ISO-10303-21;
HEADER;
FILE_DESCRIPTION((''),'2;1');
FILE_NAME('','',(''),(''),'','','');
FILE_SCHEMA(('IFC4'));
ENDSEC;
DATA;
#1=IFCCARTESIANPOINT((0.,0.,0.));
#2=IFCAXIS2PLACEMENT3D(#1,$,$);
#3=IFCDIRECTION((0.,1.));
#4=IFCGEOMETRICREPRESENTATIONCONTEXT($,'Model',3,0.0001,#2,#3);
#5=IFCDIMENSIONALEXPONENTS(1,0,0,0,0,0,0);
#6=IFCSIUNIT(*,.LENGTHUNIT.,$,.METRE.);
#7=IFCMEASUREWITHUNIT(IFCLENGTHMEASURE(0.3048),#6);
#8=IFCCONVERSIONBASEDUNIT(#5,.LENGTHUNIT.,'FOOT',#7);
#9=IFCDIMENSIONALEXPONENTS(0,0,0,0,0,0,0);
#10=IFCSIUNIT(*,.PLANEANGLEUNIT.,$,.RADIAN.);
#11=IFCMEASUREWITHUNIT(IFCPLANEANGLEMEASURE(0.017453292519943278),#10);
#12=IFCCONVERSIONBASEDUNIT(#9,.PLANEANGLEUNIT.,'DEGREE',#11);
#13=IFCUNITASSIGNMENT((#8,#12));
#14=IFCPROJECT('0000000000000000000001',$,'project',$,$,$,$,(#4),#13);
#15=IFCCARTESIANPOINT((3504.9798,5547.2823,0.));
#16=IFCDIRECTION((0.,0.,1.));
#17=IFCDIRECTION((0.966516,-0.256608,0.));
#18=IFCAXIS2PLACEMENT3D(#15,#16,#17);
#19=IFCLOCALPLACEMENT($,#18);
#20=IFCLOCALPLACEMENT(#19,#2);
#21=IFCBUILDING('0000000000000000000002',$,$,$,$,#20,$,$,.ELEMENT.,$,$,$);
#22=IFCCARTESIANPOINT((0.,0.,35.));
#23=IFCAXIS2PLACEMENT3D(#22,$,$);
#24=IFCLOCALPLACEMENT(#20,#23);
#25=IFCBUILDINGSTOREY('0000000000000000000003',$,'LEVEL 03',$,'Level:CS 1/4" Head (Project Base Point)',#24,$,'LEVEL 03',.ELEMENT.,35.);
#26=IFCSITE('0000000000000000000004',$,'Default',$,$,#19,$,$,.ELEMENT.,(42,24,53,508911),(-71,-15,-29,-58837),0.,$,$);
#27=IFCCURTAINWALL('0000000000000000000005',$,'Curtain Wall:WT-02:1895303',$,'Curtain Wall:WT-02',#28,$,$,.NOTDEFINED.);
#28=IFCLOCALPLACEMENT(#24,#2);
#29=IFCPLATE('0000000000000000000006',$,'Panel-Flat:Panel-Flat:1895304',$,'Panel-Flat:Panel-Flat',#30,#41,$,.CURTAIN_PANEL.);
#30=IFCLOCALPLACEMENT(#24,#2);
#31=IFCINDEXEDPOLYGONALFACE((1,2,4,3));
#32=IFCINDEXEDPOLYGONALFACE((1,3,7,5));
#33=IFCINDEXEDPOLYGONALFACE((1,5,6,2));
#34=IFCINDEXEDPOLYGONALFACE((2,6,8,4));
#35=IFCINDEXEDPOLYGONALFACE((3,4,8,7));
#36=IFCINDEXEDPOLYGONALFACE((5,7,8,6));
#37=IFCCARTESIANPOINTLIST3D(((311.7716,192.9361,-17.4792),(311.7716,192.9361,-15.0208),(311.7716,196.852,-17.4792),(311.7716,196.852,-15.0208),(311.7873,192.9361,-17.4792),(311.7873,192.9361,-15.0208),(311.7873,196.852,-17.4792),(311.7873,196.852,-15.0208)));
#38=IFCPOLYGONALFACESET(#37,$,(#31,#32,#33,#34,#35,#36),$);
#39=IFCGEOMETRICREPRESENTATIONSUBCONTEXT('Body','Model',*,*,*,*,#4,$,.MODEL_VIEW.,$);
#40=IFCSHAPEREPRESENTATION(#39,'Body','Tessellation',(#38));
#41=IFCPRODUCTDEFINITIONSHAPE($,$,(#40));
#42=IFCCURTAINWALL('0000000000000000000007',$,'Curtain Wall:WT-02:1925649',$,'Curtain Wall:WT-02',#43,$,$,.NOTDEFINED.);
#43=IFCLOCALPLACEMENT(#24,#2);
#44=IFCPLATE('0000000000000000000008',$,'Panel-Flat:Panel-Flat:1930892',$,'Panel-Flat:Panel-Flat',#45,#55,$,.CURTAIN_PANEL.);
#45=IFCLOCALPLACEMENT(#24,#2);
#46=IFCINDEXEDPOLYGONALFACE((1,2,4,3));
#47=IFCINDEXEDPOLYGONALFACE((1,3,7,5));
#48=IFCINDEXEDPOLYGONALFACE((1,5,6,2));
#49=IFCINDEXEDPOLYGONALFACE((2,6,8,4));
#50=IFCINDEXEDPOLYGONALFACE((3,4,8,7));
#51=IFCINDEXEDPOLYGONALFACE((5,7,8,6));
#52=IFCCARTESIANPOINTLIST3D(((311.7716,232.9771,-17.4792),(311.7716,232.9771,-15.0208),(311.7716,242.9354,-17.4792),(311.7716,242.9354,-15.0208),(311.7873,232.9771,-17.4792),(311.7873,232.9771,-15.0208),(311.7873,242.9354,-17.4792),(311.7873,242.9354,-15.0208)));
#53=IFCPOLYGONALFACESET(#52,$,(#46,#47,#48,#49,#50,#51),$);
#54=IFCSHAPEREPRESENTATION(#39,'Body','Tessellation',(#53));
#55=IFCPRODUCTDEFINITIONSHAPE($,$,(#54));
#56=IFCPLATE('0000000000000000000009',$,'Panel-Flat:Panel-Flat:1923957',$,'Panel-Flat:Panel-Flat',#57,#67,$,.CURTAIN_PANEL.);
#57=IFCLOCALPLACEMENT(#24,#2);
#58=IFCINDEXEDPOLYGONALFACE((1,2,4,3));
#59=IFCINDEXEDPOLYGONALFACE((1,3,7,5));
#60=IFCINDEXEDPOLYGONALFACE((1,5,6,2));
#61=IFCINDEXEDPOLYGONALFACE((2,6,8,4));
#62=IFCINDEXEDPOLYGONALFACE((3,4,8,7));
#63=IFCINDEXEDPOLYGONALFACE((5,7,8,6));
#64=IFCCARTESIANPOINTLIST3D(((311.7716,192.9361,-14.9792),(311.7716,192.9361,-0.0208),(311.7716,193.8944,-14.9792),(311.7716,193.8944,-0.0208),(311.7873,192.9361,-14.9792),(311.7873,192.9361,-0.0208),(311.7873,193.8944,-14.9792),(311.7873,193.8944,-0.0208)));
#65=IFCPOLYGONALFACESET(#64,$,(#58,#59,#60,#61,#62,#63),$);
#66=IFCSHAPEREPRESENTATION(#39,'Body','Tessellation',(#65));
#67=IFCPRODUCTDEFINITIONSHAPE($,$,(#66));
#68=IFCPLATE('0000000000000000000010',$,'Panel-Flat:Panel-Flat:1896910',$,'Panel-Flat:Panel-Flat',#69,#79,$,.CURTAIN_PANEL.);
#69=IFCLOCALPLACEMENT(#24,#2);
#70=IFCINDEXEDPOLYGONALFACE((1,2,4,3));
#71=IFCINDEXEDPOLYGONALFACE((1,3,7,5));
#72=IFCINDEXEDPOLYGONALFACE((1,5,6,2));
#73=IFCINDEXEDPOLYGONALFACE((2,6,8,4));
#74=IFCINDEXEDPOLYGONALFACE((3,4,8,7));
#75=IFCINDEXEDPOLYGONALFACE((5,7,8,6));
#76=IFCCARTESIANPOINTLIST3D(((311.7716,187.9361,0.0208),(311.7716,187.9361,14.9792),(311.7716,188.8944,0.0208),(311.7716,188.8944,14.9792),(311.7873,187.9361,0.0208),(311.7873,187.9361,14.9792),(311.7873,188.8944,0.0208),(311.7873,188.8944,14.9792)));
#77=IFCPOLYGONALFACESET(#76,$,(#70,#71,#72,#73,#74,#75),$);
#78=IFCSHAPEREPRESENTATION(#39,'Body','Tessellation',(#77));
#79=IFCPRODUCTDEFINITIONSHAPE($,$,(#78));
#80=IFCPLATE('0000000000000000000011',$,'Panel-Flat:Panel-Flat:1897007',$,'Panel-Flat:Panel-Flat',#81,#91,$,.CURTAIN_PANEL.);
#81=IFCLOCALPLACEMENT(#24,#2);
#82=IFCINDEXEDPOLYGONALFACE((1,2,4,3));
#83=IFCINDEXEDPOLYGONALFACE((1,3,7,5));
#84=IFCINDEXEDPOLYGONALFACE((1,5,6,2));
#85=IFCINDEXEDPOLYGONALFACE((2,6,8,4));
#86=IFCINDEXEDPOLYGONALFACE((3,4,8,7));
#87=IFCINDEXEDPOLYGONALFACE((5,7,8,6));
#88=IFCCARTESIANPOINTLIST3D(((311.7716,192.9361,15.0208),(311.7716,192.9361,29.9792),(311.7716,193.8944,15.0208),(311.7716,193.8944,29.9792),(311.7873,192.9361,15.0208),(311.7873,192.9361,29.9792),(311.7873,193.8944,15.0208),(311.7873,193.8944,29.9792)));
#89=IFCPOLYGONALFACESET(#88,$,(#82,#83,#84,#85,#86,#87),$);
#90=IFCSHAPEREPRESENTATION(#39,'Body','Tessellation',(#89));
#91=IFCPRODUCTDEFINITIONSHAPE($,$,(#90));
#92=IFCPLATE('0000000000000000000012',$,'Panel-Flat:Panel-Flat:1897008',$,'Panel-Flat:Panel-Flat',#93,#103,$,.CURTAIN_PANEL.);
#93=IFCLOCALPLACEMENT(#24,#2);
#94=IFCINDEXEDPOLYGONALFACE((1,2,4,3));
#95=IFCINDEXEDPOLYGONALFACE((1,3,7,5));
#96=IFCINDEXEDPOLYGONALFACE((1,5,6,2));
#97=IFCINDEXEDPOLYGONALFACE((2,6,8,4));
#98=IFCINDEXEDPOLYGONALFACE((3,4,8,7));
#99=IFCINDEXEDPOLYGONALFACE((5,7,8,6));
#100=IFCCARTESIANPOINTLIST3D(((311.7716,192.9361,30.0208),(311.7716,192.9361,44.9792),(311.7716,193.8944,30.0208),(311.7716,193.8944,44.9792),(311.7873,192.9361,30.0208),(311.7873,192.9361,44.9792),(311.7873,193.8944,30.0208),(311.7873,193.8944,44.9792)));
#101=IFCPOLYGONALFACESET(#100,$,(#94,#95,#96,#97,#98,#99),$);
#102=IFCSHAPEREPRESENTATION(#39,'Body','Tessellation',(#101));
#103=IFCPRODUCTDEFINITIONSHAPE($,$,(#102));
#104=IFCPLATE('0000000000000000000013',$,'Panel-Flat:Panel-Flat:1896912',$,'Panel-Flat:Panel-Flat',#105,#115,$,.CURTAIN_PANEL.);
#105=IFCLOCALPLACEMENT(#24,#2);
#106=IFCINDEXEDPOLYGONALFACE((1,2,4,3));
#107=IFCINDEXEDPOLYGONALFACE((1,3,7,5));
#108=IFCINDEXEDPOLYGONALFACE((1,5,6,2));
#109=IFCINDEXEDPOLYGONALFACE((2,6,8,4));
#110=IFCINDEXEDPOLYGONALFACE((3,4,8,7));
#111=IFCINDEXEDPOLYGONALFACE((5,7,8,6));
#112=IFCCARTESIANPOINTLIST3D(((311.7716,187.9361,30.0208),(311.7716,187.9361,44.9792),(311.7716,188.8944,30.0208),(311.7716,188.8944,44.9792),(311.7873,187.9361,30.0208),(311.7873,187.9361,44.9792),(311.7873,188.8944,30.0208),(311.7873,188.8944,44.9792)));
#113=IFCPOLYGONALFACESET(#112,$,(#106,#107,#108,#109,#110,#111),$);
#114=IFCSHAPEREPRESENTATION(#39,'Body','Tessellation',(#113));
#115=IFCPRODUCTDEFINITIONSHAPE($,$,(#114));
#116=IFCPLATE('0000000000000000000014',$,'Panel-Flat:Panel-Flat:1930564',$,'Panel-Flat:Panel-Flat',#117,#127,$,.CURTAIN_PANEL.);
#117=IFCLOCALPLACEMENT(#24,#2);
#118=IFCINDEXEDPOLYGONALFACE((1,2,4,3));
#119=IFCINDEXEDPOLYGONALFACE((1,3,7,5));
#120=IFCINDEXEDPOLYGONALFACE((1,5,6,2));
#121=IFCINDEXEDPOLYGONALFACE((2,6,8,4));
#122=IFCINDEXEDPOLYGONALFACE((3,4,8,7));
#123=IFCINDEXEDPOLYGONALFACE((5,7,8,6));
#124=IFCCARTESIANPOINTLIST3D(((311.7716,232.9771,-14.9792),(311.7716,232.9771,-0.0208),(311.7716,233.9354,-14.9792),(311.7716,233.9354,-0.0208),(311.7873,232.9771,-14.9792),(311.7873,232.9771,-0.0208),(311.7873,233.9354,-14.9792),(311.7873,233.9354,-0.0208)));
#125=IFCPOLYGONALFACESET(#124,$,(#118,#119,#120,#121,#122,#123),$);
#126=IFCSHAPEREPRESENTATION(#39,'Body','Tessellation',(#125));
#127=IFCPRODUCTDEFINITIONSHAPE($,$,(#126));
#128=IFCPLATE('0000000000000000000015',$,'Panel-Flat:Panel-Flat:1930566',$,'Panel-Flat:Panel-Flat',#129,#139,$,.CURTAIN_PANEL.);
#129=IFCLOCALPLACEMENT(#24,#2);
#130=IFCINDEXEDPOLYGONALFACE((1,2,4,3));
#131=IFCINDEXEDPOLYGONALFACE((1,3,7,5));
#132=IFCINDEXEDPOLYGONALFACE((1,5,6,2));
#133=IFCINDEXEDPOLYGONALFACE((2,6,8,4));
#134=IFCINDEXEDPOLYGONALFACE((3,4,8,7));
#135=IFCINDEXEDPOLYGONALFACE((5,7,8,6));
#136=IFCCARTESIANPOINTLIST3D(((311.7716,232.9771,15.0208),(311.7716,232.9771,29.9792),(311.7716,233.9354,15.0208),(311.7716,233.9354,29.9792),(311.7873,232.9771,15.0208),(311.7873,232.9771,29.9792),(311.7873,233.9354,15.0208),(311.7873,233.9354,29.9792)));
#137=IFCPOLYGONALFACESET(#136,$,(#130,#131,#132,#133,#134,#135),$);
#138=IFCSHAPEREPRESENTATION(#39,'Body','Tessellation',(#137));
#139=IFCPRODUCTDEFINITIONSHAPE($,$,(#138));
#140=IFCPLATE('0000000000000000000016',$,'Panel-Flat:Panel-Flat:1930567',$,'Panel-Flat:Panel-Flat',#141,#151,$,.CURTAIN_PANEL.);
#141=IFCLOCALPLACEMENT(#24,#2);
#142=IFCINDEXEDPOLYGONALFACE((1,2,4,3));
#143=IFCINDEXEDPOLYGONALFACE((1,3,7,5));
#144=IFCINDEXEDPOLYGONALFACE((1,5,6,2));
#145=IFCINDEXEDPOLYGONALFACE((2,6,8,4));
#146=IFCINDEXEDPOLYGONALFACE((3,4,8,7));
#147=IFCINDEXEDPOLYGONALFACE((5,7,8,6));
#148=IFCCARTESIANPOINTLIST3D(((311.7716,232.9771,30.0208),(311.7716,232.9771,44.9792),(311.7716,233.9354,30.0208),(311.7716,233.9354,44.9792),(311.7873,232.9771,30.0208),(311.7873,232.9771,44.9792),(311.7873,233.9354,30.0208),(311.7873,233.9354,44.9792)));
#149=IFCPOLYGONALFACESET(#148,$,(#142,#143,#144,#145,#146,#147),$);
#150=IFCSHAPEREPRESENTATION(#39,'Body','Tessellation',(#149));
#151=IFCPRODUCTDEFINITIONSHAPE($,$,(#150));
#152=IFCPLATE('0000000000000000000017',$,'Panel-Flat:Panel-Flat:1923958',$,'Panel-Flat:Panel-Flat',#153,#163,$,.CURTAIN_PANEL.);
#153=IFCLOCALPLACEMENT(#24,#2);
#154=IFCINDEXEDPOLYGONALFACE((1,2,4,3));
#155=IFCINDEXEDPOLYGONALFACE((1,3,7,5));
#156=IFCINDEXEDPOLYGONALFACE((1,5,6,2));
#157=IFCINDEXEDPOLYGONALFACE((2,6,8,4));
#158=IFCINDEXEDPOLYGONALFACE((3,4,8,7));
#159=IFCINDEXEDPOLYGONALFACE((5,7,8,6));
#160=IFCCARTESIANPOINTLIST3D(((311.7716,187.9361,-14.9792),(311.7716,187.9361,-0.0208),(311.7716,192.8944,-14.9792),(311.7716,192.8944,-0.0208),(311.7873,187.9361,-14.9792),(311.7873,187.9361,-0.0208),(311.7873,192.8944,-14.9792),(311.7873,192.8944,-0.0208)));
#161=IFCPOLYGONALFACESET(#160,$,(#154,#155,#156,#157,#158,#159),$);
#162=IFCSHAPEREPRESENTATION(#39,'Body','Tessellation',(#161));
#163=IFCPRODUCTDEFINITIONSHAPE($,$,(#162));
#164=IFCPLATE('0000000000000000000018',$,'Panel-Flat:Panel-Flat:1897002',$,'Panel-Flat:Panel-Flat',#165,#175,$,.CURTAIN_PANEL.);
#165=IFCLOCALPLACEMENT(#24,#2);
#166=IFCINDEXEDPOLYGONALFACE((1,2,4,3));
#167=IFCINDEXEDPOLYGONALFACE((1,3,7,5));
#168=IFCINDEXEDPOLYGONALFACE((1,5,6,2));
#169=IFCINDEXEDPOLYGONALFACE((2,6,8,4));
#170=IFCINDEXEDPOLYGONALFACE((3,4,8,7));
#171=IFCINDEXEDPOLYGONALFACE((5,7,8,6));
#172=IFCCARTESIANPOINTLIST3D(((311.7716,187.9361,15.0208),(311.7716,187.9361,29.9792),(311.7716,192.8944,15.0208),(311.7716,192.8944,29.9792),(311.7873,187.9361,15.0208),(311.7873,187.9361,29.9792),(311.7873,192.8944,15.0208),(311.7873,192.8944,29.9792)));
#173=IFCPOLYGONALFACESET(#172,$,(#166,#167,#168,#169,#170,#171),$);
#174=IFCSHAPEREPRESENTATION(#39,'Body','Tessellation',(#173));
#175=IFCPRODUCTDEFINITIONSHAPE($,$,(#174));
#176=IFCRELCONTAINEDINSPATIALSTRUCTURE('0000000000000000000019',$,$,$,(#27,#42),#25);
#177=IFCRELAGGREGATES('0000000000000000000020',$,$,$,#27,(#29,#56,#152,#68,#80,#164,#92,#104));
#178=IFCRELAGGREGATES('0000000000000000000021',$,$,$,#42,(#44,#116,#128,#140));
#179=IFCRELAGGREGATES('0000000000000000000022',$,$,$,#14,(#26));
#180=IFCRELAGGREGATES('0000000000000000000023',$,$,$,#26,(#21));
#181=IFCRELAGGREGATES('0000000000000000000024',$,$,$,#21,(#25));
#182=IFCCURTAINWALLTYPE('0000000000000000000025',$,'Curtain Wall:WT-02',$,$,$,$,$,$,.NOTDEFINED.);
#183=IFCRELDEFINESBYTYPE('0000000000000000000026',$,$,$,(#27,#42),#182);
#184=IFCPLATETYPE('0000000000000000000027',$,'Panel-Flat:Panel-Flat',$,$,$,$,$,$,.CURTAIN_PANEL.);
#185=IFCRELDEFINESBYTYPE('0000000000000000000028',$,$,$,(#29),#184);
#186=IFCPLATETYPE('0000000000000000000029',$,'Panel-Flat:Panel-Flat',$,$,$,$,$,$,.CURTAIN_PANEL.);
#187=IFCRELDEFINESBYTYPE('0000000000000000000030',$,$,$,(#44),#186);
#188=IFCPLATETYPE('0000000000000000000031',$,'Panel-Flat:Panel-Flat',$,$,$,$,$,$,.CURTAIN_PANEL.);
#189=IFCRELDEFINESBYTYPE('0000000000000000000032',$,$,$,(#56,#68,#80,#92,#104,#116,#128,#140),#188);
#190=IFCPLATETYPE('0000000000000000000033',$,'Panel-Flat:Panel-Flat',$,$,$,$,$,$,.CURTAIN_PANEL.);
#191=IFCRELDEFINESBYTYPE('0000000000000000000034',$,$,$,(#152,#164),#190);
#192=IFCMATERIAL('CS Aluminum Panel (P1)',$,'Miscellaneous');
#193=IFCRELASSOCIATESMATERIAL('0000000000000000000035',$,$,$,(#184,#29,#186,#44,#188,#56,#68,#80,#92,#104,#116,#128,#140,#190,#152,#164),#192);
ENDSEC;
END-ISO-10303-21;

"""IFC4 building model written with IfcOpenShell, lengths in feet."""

from ifc_helpers import new_model, entity, si_unit, converted_unit, direction, frame, origin, place, context, subcontext, project, spatial, indexed_curve, outline, extrude, source, transform, mapped, material, type_object, type_shapes, element, aggregate, save


model = new_model("IFC4")

# Units and contexts
model_context = context("Model", 3, precision=0.0001, world=origin(), true_north=direction((0.0, 1.0)))
body_context = subcontext(model_context, "Body", "Model", "MODEL_VIEW")
ifc_project = project(units=[converted_unit("LENGTHUNIT", "FOOT", entity("IfcLengthMeasure", 0.3048), si_unit("LENGTHUNIT", "METRE"), dimensions=[1, 0, 0, 0, 0, 0, 0]), converted_unit("PLANEANGLEUNIT", "DEGREE", entity("IfcPlaneAngleMeasure", 0.017453292519943278), si_unit("PLANEANGLEUNIT", "RADIAN"), dimensions=[0, 0, 0, 0, 0, 0, 0])], contexts=[model_context])

# Site, building, storey
site_placement = place(None, frame((3504.9798, 5547.2823, 0.0), z_axis=(0.0, 0.0, 1.0), x_axis=(0.966516, -0.256608, 0.0)))
site = spatial("IfcSite", under=ifc_project, at=site_placement, Name="Default", CompositionType="ELEMENT", RefLatitude=(42, 24, 53, 508911), RefLongitude=(-71, -15, -29, -58837), RefElevation=0.0)
building_placement = place(site_placement, origin())
building = spatial("IfcBuilding", under=site, at=building_placement, CompositionType="ELEMENT")
storey_placement = place(building_placement, frame((0.0, 0.0, 35.0)))
storey = spatial("IfcBuildingStorey", under=building, at=storey_placement, Name="LEVEL 03", ObjectType="Level:CS 1/4\" Head (Project Base Point)", LongName="LEVEL 03", CompositionType="ELEMENT", Elevation=35.0)

# Curtain walls, plates
curtain_wall_type = type_object("IfcCurtainWallType", Name="Curtain Wall:WT-02", PredefinedType="NOTDEFINED")
curtain_wall_1_placement = place(storey_placement, frame((0.0, 0.0, -35.0)))
curtain_wall_1 = element("IfcCurtainWall", 1, at=curtain_wall_1_placement, inside=storey, type_object=curtain_wall_type, Name="Curtain Wall:WT-02:1895303", ObjectType="Curtain Wall:WT-02", PredefinedType="NOTDEFINED")
ifc_material_1 = material(Name="CS Aluminum Panel (P1)", Category="Miscellaneous")
plate_type_1 = type_object("IfcPlateType", Name="Panel-Flat:Panel-Flat", PredefinedType="CURTAIN_PANEL", material=ifc_material_1)
shared_shape_1 = source(origin(), body_context, "Body", "SweptSolid", [
    extrude(outline(indexed_curve([(-0.0078, -1.958), (0.0078, -1.958), (0.0078, 1.958), (-0.0078, 1.958), (-0.0078, -1.958)], self_intersect=False)), frame((0.0, -0.0078, 0.0208), z_axis=(0.0, 0.0, 1.0), x_axis=(0.0, -1.0, 0.0)), (0.0, 0.0, 1.0), 2.4583),
])
type_shapes(plate_type_1, [shared_shape_1])
plate_1_placement = place(curtain_wall_1_placement, frame((311.7873, 194.8941, 17.5), z_axis=(0.0, 0.0, 1.0), x_axis=(0.0, -1.0, 0.0)))
plate_1 = element("IfcPlate", 2, at=plate_1_placement, type_object=plate_type_1, material=ifc_material_1, Name="Panel-Flat:Panel-Flat:1895304", ObjectType="Panel-Flat:Panel-Flat", PredefinedType="CURTAIN_PANEL", context=body_context, shape_type="MappedRepresentation", body=[
    mapped(shared_shape_1, transform((0.0, 0.0, 0.0), scale=1.0)),
])
curtain_wall_2_placement = place(storey_placement, frame((0.0, 0.0, -35.0)))
curtain_wall_2 = element("IfcCurtainWall", 3, at=curtain_wall_2_placement, inside=storey, type_object=curtain_wall_type, Name="Curtain Wall:WT-02:1925649", ObjectType="Curtain Wall:WT-02", PredefinedType="NOTDEFINED")
plate_type_2 = type_object("IfcPlateType", Name="Panel-Flat:Panel-Flat", PredefinedType="CURTAIN_PANEL", material=ifc_material_1)
shared_shape_2 = source(origin(), body_context, "Body", "SweptSolid", [
    extrude(outline(indexed_curve([(-0.0078, -4.9792), (0.0078, -4.9792), (0.0078, 4.9792), (-0.0078, 4.9792), (-0.0078, -4.9792)], self_intersect=False)), frame((0.0, -0.0078, 0.0208), z_axis=(0.0, 0.0, 1.0), x_axis=(0.0, -1.0, 0.0)), (0.0, 0.0, 1.0), 2.4583),
])
type_shapes(plate_type_2, [shared_shape_2])
plate_2_placement = place(curtain_wall_2_placement, frame((311.7873, 237.9563, 17.5), z_axis=(0.0, 0.0, 1.0), x_axis=(0.0, -1.0, 0.0)))
plate_2 = element("IfcPlate", 4, at=plate_2_placement, type_object=plate_type_2, material=ifc_material_1, Name="Panel-Flat:Panel-Flat:1930892", ObjectType="Panel-Flat:Panel-Flat", PredefinedType="CURTAIN_PANEL", context=body_context, shape_type="MappedRepresentation", body=[
    mapped(shared_shape_2, transform((0.0, 0.0, 0.0), scale=1.0)),
])

# Plates
plate_type_3 = type_object("IfcPlateType", Name="Panel-Flat:Panel-Flat", PredefinedType="CURTAIN_PANEL", material=ifc_material_1)
shared_shape_3 = source(origin(), body_context, "Body", "SweptSolid", [
    extrude(outline(indexed_curve([(-0.0078, -0.4792), (0.0078, -0.4792), (0.0078, 0.4792), (-0.0078, 0.4792), (-0.0078, -0.4792)], self_intersect=False)), frame((0.0, -0.0078, 0.0208), z_axis=(0.0, 0.0, 1.0), x_axis=(0.0, -1.0, 0.0)), (0.0, 0.0, 1.0), 14.9583),
])
type_shapes(plate_type_3, [shared_shape_3])
plate_3_placement = place(curtain_wall_1_placement, frame((311.7873, 193.4153, 20.0), z_axis=(0.0, 0.0, 1.0), x_axis=(0.0, -1.0, 0.0)))
plate_3 = element("IfcPlate", 5, at=plate_3_placement, type_object=plate_type_3, material=ifc_material_1, Name="Panel-Flat:Panel-Flat:1923957", ObjectType="Panel-Flat:Panel-Flat", PredefinedType="CURTAIN_PANEL", context=body_context, shape_type="MappedRepresentation", body=[
    mapped(shared_shape_3, transform((0.0, 0.0, 0.0), scale=1.0)),
])
plate_4_placement = place(curtain_wall_1_placement, frame((311.7873, 188.4153, 35.0), z_axis=(0.0, 0.0, 1.0), x_axis=(0.0, -1.0, 0.0)))
plate_4 = element("IfcPlate", 6, at=plate_4_placement, type_object=plate_type_3, material=ifc_material_1, Name="Panel-Flat:Panel-Flat:1896910", ObjectType="Panel-Flat:Panel-Flat", PredefinedType="CURTAIN_PANEL", context=body_context, shape_type="MappedRepresentation", body=[
    mapped(shared_shape_3, transform((0.0, 0.0, 0.0), scale=1.0)),
])
plate_5_placement = place(curtain_wall_1_placement, frame((311.7873, 193.4153, 50.0), z_axis=(0.0, 0.0, 1.0), x_axis=(0.0, -1.0, 0.0)))
plate_5 = element("IfcPlate", 7, at=plate_5_placement, type_object=plate_type_3, material=ifc_material_1, Name="Panel-Flat:Panel-Flat:1897007", ObjectType="Panel-Flat:Panel-Flat", PredefinedType="CURTAIN_PANEL", context=body_context, shape_type="MappedRepresentation", body=[
    mapped(shared_shape_3, transform((0.0, 0.0, 0.0), scale=1.0)),
])
plate_6_placement = place(curtain_wall_1_placement, frame((311.7873, 193.4153, 65.0), z_axis=(0.0, 0.0, 1.0), x_axis=(0.0, -1.0, 0.0)))
plate_6 = element("IfcPlate", 8, at=plate_6_placement, type_object=plate_type_3, material=ifc_material_1, Name="Panel-Flat:Panel-Flat:1897008", ObjectType="Panel-Flat:Panel-Flat", PredefinedType="CURTAIN_PANEL", context=body_context, shape_type="MappedRepresentation", body=[
    mapped(shared_shape_3, transform((0.0, 0.0, 0.0), scale=1.0)),
])
plate_7_placement = place(curtain_wall_1_placement, frame((311.7873, 188.4153, 65.0), z_axis=(0.0, 0.0, 1.0), x_axis=(0.0, -1.0, 0.0)))
plate_7 = element("IfcPlate", 9, at=plate_7_placement, type_object=plate_type_3, material=ifc_material_1, Name="Panel-Flat:Panel-Flat:1896912", ObjectType="Panel-Flat:Panel-Flat", PredefinedType="CURTAIN_PANEL", context=body_context, shape_type="MappedRepresentation", body=[
    mapped(shared_shape_3, transform((0.0, 0.0, 0.0), scale=1.0)),
])
plate_8_placement = place(curtain_wall_2_placement, frame((311.7873, 233.4563, 20.0), z_axis=(0.0, 0.0, 1.0), x_axis=(0.0, -1.0, 0.0)))
plate_8 = element("IfcPlate", 10, at=plate_8_placement, type_object=plate_type_3, material=ifc_material_1, Name="Panel-Flat:Panel-Flat:1930564", ObjectType="Panel-Flat:Panel-Flat", PredefinedType="CURTAIN_PANEL", context=body_context, shape_type="MappedRepresentation", body=[
    mapped(shared_shape_3, transform((0.0, 0.0, 0.0), scale=1.0)),
])
plate_9_placement = place(curtain_wall_2_placement, frame((311.7873, 233.4563, 50.0), z_axis=(0.0, 0.0, 1.0), x_axis=(0.0, -1.0, 0.0)))
plate_9 = element("IfcPlate", 11, at=plate_9_placement, type_object=plate_type_3, material=ifc_material_1, Name="Panel-Flat:Panel-Flat:1930566", ObjectType="Panel-Flat:Panel-Flat", PredefinedType="CURTAIN_PANEL", context=body_context, shape_type="MappedRepresentation", body=[
    mapped(shared_shape_3, transform((0.0, 0.0, 0.0), scale=1.0)),
])
plate_10_placement = place(curtain_wall_2_placement, frame((311.7873, 233.4563, 65.0), z_axis=(0.0, 0.0, 1.0), x_axis=(0.0, -1.0, 0.0)))
plate_10 = element("IfcPlate", 12, at=plate_10_placement, type_object=plate_type_3, material=ifc_material_1, Name="Panel-Flat:Panel-Flat:1930567", ObjectType="Panel-Flat:Panel-Flat", PredefinedType="CURTAIN_PANEL", context=body_context, shape_type="MappedRepresentation", body=[
    mapped(shared_shape_3, transform((0.0, 0.0, 0.0), scale=1.0)),
])
plate_type_4 = type_object("IfcPlateType", Name="Panel-Flat:Panel-Flat", PredefinedType="CURTAIN_PANEL", material=ifc_material_1)
shared_shape_4 = source(origin(), body_context, "Body", "SweptSolid", [
    extrude(outline(indexed_curve([(-0.0078, -2.4792), (0.0078, -2.4792), (0.0078, 2.4792), (-0.0078, 2.4792), (-0.0078, -2.4792)], self_intersect=False)), frame((0.0, -0.0078, 0.0208), z_axis=(0.0, 0.0, 1.0), x_axis=(0.0, -1.0, 0.0)), (0.0, 0.0, 1.0), 14.9583),
])
type_shapes(plate_type_4, [shared_shape_4])
plate_11_placement = place(curtain_wall_1_placement, frame((311.7873, 190.4153, 20.0), z_axis=(0.0, 0.0, 1.0), x_axis=(0.0, -1.0, 0.0)))
plate_11 = element("IfcPlate", 13, at=plate_11_placement, type_object=plate_type_4, material=ifc_material_1, Name="Panel-Flat:Panel-Flat:1923958", ObjectType="Panel-Flat:Panel-Flat", PredefinedType="CURTAIN_PANEL", context=body_context, shape_type="MappedRepresentation", body=[
    mapped(shared_shape_4, transform((0.0, 0.0, 0.0), scale=1.0)),
])
plate_12_placement = place(curtain_wall_1_placement, frame((311.7873, 190.4153, 50.0), z_axis=(0.0, 0.0, 1.0), x_axis=(0.0, -1.0, 0.0)))
plate_12 = element("IfcPlate", 14, at=plate_12_placement, type_object=plate_type_4, material=ifc_material_1, Name="Panel-Flat:Panel-Flat:1897002", ObjectType="Panel-Flat:Panel-Flat", PredefinedType="CURTAIN_PANEL", context=body_context, shape_type="MappedRepresentation", body=[
    mapped(shared_shape_4, transform((0.0, 0.0, 0.0), scale=1.0)),
])
aggregate(curtain_wall_1, [plate_1, plate_3, plate_11, plate_4, plate_5, plate_12, plate_6, plate_7])
aggregate(curtain_wall_2, [plate_2, plate_8, plate_9, plate_10])

save(model, "model.ifc")
